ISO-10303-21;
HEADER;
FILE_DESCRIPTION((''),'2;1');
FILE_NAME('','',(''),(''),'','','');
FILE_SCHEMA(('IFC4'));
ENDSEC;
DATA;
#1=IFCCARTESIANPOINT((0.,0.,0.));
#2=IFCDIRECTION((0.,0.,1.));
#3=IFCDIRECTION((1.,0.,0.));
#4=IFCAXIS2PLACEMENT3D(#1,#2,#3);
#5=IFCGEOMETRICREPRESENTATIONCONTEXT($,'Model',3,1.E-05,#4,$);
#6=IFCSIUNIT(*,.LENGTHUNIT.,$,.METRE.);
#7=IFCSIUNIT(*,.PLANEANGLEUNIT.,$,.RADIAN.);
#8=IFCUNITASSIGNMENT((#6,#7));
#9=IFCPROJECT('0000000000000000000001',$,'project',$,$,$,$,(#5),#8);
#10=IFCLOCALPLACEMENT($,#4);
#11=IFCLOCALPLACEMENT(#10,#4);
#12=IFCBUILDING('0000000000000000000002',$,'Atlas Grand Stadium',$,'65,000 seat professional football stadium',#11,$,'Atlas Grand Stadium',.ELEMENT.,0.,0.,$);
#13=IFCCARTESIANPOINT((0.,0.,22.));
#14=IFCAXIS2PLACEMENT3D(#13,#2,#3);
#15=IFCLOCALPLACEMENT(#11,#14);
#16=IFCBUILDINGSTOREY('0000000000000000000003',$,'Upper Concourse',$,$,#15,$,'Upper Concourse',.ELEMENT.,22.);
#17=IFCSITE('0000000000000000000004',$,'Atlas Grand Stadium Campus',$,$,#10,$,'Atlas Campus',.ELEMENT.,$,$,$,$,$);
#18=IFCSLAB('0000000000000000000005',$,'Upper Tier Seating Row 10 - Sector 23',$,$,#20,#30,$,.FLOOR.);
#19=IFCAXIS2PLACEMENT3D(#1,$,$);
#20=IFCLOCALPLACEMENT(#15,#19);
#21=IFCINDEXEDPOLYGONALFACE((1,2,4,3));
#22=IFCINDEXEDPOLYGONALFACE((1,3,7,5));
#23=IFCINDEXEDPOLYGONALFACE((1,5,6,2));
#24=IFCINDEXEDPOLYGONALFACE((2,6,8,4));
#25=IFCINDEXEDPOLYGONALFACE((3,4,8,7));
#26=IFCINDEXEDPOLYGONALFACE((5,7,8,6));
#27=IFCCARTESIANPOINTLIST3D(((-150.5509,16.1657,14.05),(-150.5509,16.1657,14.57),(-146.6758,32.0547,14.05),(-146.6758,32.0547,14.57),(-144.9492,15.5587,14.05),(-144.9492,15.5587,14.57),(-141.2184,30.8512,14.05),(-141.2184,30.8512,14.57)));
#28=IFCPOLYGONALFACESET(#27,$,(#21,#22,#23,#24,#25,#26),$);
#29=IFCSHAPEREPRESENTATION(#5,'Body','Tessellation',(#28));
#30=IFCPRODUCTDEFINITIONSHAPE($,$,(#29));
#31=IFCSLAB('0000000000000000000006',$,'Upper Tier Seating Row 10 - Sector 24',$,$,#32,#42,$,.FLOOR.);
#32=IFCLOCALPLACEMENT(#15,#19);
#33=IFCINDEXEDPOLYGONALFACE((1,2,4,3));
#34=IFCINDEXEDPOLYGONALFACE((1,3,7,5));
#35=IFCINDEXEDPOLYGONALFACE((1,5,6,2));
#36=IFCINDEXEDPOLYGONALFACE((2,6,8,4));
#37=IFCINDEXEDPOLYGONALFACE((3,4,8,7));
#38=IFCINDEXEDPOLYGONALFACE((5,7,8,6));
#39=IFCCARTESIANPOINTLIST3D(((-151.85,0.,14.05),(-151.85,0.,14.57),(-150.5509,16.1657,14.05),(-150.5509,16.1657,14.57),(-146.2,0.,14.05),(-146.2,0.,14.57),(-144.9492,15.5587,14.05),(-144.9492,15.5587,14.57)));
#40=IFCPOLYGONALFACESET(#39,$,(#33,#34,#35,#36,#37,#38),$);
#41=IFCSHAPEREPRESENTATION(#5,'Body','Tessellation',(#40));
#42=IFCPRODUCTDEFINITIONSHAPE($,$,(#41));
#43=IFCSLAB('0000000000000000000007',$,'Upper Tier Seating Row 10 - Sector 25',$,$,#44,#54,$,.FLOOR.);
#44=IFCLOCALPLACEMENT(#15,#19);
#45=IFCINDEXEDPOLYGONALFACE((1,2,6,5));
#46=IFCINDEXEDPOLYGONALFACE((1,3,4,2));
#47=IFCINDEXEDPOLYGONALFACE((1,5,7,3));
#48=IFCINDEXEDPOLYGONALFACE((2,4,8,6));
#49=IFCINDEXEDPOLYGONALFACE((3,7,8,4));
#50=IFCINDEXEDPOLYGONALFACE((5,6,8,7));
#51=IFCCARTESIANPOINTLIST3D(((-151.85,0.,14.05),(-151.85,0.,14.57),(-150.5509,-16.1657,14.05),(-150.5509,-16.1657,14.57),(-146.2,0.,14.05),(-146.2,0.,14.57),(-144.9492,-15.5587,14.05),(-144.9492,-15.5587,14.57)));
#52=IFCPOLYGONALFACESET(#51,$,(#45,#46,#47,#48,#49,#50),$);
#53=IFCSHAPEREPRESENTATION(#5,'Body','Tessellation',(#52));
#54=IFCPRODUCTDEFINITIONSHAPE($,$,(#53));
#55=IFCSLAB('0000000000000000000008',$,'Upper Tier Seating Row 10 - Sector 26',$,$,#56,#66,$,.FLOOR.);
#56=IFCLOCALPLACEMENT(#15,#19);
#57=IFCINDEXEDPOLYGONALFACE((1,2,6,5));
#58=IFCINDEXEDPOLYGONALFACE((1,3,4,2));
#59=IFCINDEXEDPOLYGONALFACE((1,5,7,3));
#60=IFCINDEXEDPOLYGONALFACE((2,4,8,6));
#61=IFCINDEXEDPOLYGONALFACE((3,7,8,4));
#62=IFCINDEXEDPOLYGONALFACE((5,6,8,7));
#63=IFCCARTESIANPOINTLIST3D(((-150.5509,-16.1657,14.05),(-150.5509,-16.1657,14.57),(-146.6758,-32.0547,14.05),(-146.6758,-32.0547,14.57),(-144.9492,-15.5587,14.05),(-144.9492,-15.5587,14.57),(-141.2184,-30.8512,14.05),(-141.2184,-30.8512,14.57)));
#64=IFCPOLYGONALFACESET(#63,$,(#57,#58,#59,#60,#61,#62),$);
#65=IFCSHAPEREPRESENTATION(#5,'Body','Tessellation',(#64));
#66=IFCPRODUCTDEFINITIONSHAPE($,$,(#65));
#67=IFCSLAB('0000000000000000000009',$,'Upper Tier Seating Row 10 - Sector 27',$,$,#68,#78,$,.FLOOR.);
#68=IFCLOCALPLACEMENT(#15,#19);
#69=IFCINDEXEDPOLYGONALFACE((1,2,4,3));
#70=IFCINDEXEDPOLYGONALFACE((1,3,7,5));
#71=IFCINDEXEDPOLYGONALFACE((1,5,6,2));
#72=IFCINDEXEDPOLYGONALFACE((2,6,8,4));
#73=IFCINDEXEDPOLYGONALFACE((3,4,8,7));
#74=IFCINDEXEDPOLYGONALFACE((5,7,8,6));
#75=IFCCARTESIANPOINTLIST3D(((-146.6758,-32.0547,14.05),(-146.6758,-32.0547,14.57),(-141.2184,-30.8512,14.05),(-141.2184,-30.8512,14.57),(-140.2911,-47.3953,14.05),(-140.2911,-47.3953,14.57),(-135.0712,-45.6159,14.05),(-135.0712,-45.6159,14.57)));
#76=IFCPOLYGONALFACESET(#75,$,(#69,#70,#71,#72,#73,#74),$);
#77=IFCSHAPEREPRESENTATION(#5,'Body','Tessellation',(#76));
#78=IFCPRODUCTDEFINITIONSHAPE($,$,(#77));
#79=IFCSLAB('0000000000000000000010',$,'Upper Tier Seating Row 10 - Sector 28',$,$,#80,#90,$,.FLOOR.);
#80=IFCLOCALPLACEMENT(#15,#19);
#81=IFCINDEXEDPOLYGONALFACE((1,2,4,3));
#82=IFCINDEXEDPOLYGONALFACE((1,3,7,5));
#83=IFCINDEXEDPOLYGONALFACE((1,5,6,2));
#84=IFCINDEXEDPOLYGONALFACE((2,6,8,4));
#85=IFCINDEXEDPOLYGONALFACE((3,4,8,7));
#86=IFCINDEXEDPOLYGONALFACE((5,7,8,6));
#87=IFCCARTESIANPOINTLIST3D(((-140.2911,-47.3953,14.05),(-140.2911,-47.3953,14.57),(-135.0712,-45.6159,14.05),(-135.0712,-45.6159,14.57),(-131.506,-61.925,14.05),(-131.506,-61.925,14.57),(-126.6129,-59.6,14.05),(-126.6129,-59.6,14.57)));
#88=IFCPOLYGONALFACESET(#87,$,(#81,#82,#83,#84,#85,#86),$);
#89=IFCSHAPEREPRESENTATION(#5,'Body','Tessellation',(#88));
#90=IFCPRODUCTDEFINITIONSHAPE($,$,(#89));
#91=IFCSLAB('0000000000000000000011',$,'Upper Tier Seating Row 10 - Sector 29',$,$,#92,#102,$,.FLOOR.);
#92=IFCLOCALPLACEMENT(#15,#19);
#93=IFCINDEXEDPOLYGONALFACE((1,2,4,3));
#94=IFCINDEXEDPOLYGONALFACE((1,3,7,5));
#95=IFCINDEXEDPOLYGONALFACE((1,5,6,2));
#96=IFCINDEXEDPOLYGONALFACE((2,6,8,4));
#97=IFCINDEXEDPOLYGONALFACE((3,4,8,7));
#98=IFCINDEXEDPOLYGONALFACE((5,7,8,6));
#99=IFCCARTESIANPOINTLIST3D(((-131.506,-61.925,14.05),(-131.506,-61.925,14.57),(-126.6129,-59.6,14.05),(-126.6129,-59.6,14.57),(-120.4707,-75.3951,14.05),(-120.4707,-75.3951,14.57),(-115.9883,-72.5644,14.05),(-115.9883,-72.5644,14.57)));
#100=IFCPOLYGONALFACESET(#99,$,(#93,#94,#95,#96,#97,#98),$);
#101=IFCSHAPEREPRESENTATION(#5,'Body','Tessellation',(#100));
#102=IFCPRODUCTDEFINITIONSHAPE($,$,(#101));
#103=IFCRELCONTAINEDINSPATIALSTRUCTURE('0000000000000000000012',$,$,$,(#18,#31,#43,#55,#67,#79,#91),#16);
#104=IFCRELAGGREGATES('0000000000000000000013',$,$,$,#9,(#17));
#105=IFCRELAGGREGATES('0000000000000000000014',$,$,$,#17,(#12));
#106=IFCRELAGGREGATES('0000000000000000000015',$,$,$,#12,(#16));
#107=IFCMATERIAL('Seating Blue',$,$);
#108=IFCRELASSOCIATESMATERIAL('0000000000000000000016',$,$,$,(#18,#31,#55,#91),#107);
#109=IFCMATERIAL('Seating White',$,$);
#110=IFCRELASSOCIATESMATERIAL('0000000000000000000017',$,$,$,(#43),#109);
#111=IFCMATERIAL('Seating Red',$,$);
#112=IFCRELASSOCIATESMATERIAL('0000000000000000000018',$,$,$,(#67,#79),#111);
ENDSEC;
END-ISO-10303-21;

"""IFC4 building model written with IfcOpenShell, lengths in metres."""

from ifc_helpers import new_model, si_unit, frame, origin_with_axes, place, context, project, spatial, polyline, outline, extrude, material, element, save


model = new_model("IFC4")

# Units and contexts
model_context = context("Model", 3, precision=1e-05, world=origin_with_axes())
ifc_project = project(units=[si_unit("LENGTHUNIT", "METRE"), si_unit("PLANEANGLEUNIT", "RADIAN")], contexts=[model_context])

# Site, building, storey
site_placement = place(None, origin_with_axes())
site = spatial("IfcSite", under=ifc_project, at=site_placement, Name="Atlas Grand Stadium Campus", LongName="Atlas Campus", CompositionType="ELEMENT")
building_placement = place(site_placement, origin_with_axes())
building = spatial("IfcBuilding", under=site, at=building_placement, Name="Atlas Grand Stadium", ObjectType="65,000 seat professional football stadium", LongName="Atlas Grand Stadium", CompositionType="ELEMENT", ElevationOfRefHeight=0.0, ElevationOfTerrain=0.0)
storey_placement = place(building_placement, frame((0.0, 0.0, 22.0), z_axis=(0.0, 0.0, 1.0), x_axis=(1.0, 0.0, 0.0)))
storey = spatial("IfcBuildingStorey", under=building, at=storey_placement, Name="Upper Concourse", LongName="Upper Concourse", CompositionType="ELEMENT", Elevation=22.0)

# Slabs
ifc_material_1 = material(Name="Seating Red")
ifc_material_2 = material(Name="Seating Blue")
ifc_material_3 = material(Name="Seating White")
slab_1_placement = place(storey_placement, frame((0.0, 0.0, 14.05), z_axis=(0.0, 0.0, 1.0), x_axis=(1.0, 0.0, 0.0)))
element("IfcSlab", 1, at=slab_1_placement, inside=storey, material=ifc_material_2, Name="Upper Tier Seating Row 10 - Sector 23", PredefinedType="FLOOR", context=model_context, shape_type="SweptSolid", body=[
    extrude(outline(polyline([(-146.6758, 32.0547), (-150.5509, 16.1657), (-144.9492, 15.5587), (-141.2184, 30.8512), (-146.6758, 32.0547)])), origin_with_axes(), (0.0, 0.0, 1.0), 0.52),
])
slab_2_placement = place(storey_placement, frame((0.0, 0.0, 14.05), z_axis=(0.0, 0.0, 1.0), x_axis=(1.0, 0.0, 0.0)))
element("IfcSlab", 2, at=slab_2_placement, inside=storey, material=ifc_material_2, Name="Upper Tier Seating Row 10 - Sector 24", PredefinedType="FLOOR", context=model_context, shape_type="SweptSolid", body=[
    extrude(outline(polyline([(-150.5509, 16.1657), (-151.85, 0.0), (-146.2, 0.0), (-144.9492, 15.5587), (-150.5509, 16.1657)])), origin_with_axes(), (0.0, 0.0, 1.0), 0.52),
])
slab_3_placement = place(storey_placement, frame((0.0, 0.0, 14.05), z_axis=(0.0, 0.0, 1.0), x_axis=(1.0, 0.0, 0.0)))
element("IfcSlab", 3, at=slab_3_placement, inside=storey, material=ifc_material_3, Name="Upper Tier Seating Row 10 - Sector 25", PredefinedType="FLOOR", context=model_context, shape_type="SweptSolid", body=[
    extrude(outline(polyline([(-151.85, 0.0), (-150.5509, -16.1657), (-144.9492, -15.5587), (-146.2, 0.0), (-151.85, 0.0)])), origin_with_axes(), (0.0, 0.0, 1.0), 0.52),
])
slab_4_placement = place(storey_placement, frame((0.0, 0.0, 14.05), z_axis=(0.0, 0.0, 1.0), x_axis=(1.0, 0.0, 0.0)))
element("IfcSlab", 4, at=slab_4_placement, inside=storey, material=ifc_material_2, Name="Upper Tier Seating Row 10 - Sector 26", PredefinedType="FLOOR", context=model_context, shape_type="SweptSolid", body=[
    extrude(outline(polyline([(-150.5509, -16.1657), (-146.6758, -32.0547), (-141.2184, -30.8512), (-144.9492, -15.5587), (-150.5509, -16.1657)])), origin_with_axes(), (0.0, 0.0, 1.0), 0.52),
])
slab_5_placement = place(storey_placement, frame((0.0, 0.0, 14.05), z_axis=(0.0, 0.0, 1.0), x_axis=(1.0, 0.0, 0.0)))
element("IfcSlab", 5, at=slab_5_placement, inside=storey, material=ifc_material_1, Name="Upper Tier Seating Row 10 - Sector 27", PredefinedType="FLOOR", context=model_context, shape_type="SweptSolid", body=[
    extrude(outline(polyline([(-146.6758, -32.0547), (-140.2911, -47.3953), (-135.0712, -45.6159), (-141.2184, -30.8512), (-146.6758, -32.0547)])), origin_with_axes(), (0.0, 0.0, 1.0), 0.52),
])
slab_6_placement = place(storey_placement, frame((0.0, 0.0, 14.05), z_axis=(0.0, 0.0, 1.0), x_axis=(1.0, 0.0, 0.0)))
element("IfcSlab", 6, at=slab_6_placement, inside=storey, material=ifc_material_1, Name="Upper Tier Seating Row 10 - Sector 28", PredefinedType="FLOOR", context=model_context, shape_type="SweptSolid", body=[
    extrude(outline(polyline([(-140.2911, -47.3953), (-131.506, -61.925), (-126.6129, -59.6), (-135.0712, -45.6159), (-140.2911, -47.3953)])), origin_with_axes(), (0.0, 0.0, 1.0), 0.52),
])
slab_7_placement = place(storey_placement, frame((0.0, 0.0, 14.05), z_axis=(0.0, 0.0, 1.0), x_axis=(1.0, 0.0, 0.0)))
element("IfcSlab", 7, at=slab_7_placement, inside=storey, material=ifc_material_2, Name="Upper Tier Seating Row 10 - Sector 29", PredefinedType="FLOOR", context=model_context, shape_type="SweptSolid", body=[
    extrude(outline(polyline([(-131.506, -61.925), (-120.4707, -75.3951), (-115.9883, -72.5644), (-126.6129, -59.6), (-131.506, -61.925)])), origin_with_axes(), (0.0, 0.0, 1.0), 0.52),
])

save(model, "model.ifc")
